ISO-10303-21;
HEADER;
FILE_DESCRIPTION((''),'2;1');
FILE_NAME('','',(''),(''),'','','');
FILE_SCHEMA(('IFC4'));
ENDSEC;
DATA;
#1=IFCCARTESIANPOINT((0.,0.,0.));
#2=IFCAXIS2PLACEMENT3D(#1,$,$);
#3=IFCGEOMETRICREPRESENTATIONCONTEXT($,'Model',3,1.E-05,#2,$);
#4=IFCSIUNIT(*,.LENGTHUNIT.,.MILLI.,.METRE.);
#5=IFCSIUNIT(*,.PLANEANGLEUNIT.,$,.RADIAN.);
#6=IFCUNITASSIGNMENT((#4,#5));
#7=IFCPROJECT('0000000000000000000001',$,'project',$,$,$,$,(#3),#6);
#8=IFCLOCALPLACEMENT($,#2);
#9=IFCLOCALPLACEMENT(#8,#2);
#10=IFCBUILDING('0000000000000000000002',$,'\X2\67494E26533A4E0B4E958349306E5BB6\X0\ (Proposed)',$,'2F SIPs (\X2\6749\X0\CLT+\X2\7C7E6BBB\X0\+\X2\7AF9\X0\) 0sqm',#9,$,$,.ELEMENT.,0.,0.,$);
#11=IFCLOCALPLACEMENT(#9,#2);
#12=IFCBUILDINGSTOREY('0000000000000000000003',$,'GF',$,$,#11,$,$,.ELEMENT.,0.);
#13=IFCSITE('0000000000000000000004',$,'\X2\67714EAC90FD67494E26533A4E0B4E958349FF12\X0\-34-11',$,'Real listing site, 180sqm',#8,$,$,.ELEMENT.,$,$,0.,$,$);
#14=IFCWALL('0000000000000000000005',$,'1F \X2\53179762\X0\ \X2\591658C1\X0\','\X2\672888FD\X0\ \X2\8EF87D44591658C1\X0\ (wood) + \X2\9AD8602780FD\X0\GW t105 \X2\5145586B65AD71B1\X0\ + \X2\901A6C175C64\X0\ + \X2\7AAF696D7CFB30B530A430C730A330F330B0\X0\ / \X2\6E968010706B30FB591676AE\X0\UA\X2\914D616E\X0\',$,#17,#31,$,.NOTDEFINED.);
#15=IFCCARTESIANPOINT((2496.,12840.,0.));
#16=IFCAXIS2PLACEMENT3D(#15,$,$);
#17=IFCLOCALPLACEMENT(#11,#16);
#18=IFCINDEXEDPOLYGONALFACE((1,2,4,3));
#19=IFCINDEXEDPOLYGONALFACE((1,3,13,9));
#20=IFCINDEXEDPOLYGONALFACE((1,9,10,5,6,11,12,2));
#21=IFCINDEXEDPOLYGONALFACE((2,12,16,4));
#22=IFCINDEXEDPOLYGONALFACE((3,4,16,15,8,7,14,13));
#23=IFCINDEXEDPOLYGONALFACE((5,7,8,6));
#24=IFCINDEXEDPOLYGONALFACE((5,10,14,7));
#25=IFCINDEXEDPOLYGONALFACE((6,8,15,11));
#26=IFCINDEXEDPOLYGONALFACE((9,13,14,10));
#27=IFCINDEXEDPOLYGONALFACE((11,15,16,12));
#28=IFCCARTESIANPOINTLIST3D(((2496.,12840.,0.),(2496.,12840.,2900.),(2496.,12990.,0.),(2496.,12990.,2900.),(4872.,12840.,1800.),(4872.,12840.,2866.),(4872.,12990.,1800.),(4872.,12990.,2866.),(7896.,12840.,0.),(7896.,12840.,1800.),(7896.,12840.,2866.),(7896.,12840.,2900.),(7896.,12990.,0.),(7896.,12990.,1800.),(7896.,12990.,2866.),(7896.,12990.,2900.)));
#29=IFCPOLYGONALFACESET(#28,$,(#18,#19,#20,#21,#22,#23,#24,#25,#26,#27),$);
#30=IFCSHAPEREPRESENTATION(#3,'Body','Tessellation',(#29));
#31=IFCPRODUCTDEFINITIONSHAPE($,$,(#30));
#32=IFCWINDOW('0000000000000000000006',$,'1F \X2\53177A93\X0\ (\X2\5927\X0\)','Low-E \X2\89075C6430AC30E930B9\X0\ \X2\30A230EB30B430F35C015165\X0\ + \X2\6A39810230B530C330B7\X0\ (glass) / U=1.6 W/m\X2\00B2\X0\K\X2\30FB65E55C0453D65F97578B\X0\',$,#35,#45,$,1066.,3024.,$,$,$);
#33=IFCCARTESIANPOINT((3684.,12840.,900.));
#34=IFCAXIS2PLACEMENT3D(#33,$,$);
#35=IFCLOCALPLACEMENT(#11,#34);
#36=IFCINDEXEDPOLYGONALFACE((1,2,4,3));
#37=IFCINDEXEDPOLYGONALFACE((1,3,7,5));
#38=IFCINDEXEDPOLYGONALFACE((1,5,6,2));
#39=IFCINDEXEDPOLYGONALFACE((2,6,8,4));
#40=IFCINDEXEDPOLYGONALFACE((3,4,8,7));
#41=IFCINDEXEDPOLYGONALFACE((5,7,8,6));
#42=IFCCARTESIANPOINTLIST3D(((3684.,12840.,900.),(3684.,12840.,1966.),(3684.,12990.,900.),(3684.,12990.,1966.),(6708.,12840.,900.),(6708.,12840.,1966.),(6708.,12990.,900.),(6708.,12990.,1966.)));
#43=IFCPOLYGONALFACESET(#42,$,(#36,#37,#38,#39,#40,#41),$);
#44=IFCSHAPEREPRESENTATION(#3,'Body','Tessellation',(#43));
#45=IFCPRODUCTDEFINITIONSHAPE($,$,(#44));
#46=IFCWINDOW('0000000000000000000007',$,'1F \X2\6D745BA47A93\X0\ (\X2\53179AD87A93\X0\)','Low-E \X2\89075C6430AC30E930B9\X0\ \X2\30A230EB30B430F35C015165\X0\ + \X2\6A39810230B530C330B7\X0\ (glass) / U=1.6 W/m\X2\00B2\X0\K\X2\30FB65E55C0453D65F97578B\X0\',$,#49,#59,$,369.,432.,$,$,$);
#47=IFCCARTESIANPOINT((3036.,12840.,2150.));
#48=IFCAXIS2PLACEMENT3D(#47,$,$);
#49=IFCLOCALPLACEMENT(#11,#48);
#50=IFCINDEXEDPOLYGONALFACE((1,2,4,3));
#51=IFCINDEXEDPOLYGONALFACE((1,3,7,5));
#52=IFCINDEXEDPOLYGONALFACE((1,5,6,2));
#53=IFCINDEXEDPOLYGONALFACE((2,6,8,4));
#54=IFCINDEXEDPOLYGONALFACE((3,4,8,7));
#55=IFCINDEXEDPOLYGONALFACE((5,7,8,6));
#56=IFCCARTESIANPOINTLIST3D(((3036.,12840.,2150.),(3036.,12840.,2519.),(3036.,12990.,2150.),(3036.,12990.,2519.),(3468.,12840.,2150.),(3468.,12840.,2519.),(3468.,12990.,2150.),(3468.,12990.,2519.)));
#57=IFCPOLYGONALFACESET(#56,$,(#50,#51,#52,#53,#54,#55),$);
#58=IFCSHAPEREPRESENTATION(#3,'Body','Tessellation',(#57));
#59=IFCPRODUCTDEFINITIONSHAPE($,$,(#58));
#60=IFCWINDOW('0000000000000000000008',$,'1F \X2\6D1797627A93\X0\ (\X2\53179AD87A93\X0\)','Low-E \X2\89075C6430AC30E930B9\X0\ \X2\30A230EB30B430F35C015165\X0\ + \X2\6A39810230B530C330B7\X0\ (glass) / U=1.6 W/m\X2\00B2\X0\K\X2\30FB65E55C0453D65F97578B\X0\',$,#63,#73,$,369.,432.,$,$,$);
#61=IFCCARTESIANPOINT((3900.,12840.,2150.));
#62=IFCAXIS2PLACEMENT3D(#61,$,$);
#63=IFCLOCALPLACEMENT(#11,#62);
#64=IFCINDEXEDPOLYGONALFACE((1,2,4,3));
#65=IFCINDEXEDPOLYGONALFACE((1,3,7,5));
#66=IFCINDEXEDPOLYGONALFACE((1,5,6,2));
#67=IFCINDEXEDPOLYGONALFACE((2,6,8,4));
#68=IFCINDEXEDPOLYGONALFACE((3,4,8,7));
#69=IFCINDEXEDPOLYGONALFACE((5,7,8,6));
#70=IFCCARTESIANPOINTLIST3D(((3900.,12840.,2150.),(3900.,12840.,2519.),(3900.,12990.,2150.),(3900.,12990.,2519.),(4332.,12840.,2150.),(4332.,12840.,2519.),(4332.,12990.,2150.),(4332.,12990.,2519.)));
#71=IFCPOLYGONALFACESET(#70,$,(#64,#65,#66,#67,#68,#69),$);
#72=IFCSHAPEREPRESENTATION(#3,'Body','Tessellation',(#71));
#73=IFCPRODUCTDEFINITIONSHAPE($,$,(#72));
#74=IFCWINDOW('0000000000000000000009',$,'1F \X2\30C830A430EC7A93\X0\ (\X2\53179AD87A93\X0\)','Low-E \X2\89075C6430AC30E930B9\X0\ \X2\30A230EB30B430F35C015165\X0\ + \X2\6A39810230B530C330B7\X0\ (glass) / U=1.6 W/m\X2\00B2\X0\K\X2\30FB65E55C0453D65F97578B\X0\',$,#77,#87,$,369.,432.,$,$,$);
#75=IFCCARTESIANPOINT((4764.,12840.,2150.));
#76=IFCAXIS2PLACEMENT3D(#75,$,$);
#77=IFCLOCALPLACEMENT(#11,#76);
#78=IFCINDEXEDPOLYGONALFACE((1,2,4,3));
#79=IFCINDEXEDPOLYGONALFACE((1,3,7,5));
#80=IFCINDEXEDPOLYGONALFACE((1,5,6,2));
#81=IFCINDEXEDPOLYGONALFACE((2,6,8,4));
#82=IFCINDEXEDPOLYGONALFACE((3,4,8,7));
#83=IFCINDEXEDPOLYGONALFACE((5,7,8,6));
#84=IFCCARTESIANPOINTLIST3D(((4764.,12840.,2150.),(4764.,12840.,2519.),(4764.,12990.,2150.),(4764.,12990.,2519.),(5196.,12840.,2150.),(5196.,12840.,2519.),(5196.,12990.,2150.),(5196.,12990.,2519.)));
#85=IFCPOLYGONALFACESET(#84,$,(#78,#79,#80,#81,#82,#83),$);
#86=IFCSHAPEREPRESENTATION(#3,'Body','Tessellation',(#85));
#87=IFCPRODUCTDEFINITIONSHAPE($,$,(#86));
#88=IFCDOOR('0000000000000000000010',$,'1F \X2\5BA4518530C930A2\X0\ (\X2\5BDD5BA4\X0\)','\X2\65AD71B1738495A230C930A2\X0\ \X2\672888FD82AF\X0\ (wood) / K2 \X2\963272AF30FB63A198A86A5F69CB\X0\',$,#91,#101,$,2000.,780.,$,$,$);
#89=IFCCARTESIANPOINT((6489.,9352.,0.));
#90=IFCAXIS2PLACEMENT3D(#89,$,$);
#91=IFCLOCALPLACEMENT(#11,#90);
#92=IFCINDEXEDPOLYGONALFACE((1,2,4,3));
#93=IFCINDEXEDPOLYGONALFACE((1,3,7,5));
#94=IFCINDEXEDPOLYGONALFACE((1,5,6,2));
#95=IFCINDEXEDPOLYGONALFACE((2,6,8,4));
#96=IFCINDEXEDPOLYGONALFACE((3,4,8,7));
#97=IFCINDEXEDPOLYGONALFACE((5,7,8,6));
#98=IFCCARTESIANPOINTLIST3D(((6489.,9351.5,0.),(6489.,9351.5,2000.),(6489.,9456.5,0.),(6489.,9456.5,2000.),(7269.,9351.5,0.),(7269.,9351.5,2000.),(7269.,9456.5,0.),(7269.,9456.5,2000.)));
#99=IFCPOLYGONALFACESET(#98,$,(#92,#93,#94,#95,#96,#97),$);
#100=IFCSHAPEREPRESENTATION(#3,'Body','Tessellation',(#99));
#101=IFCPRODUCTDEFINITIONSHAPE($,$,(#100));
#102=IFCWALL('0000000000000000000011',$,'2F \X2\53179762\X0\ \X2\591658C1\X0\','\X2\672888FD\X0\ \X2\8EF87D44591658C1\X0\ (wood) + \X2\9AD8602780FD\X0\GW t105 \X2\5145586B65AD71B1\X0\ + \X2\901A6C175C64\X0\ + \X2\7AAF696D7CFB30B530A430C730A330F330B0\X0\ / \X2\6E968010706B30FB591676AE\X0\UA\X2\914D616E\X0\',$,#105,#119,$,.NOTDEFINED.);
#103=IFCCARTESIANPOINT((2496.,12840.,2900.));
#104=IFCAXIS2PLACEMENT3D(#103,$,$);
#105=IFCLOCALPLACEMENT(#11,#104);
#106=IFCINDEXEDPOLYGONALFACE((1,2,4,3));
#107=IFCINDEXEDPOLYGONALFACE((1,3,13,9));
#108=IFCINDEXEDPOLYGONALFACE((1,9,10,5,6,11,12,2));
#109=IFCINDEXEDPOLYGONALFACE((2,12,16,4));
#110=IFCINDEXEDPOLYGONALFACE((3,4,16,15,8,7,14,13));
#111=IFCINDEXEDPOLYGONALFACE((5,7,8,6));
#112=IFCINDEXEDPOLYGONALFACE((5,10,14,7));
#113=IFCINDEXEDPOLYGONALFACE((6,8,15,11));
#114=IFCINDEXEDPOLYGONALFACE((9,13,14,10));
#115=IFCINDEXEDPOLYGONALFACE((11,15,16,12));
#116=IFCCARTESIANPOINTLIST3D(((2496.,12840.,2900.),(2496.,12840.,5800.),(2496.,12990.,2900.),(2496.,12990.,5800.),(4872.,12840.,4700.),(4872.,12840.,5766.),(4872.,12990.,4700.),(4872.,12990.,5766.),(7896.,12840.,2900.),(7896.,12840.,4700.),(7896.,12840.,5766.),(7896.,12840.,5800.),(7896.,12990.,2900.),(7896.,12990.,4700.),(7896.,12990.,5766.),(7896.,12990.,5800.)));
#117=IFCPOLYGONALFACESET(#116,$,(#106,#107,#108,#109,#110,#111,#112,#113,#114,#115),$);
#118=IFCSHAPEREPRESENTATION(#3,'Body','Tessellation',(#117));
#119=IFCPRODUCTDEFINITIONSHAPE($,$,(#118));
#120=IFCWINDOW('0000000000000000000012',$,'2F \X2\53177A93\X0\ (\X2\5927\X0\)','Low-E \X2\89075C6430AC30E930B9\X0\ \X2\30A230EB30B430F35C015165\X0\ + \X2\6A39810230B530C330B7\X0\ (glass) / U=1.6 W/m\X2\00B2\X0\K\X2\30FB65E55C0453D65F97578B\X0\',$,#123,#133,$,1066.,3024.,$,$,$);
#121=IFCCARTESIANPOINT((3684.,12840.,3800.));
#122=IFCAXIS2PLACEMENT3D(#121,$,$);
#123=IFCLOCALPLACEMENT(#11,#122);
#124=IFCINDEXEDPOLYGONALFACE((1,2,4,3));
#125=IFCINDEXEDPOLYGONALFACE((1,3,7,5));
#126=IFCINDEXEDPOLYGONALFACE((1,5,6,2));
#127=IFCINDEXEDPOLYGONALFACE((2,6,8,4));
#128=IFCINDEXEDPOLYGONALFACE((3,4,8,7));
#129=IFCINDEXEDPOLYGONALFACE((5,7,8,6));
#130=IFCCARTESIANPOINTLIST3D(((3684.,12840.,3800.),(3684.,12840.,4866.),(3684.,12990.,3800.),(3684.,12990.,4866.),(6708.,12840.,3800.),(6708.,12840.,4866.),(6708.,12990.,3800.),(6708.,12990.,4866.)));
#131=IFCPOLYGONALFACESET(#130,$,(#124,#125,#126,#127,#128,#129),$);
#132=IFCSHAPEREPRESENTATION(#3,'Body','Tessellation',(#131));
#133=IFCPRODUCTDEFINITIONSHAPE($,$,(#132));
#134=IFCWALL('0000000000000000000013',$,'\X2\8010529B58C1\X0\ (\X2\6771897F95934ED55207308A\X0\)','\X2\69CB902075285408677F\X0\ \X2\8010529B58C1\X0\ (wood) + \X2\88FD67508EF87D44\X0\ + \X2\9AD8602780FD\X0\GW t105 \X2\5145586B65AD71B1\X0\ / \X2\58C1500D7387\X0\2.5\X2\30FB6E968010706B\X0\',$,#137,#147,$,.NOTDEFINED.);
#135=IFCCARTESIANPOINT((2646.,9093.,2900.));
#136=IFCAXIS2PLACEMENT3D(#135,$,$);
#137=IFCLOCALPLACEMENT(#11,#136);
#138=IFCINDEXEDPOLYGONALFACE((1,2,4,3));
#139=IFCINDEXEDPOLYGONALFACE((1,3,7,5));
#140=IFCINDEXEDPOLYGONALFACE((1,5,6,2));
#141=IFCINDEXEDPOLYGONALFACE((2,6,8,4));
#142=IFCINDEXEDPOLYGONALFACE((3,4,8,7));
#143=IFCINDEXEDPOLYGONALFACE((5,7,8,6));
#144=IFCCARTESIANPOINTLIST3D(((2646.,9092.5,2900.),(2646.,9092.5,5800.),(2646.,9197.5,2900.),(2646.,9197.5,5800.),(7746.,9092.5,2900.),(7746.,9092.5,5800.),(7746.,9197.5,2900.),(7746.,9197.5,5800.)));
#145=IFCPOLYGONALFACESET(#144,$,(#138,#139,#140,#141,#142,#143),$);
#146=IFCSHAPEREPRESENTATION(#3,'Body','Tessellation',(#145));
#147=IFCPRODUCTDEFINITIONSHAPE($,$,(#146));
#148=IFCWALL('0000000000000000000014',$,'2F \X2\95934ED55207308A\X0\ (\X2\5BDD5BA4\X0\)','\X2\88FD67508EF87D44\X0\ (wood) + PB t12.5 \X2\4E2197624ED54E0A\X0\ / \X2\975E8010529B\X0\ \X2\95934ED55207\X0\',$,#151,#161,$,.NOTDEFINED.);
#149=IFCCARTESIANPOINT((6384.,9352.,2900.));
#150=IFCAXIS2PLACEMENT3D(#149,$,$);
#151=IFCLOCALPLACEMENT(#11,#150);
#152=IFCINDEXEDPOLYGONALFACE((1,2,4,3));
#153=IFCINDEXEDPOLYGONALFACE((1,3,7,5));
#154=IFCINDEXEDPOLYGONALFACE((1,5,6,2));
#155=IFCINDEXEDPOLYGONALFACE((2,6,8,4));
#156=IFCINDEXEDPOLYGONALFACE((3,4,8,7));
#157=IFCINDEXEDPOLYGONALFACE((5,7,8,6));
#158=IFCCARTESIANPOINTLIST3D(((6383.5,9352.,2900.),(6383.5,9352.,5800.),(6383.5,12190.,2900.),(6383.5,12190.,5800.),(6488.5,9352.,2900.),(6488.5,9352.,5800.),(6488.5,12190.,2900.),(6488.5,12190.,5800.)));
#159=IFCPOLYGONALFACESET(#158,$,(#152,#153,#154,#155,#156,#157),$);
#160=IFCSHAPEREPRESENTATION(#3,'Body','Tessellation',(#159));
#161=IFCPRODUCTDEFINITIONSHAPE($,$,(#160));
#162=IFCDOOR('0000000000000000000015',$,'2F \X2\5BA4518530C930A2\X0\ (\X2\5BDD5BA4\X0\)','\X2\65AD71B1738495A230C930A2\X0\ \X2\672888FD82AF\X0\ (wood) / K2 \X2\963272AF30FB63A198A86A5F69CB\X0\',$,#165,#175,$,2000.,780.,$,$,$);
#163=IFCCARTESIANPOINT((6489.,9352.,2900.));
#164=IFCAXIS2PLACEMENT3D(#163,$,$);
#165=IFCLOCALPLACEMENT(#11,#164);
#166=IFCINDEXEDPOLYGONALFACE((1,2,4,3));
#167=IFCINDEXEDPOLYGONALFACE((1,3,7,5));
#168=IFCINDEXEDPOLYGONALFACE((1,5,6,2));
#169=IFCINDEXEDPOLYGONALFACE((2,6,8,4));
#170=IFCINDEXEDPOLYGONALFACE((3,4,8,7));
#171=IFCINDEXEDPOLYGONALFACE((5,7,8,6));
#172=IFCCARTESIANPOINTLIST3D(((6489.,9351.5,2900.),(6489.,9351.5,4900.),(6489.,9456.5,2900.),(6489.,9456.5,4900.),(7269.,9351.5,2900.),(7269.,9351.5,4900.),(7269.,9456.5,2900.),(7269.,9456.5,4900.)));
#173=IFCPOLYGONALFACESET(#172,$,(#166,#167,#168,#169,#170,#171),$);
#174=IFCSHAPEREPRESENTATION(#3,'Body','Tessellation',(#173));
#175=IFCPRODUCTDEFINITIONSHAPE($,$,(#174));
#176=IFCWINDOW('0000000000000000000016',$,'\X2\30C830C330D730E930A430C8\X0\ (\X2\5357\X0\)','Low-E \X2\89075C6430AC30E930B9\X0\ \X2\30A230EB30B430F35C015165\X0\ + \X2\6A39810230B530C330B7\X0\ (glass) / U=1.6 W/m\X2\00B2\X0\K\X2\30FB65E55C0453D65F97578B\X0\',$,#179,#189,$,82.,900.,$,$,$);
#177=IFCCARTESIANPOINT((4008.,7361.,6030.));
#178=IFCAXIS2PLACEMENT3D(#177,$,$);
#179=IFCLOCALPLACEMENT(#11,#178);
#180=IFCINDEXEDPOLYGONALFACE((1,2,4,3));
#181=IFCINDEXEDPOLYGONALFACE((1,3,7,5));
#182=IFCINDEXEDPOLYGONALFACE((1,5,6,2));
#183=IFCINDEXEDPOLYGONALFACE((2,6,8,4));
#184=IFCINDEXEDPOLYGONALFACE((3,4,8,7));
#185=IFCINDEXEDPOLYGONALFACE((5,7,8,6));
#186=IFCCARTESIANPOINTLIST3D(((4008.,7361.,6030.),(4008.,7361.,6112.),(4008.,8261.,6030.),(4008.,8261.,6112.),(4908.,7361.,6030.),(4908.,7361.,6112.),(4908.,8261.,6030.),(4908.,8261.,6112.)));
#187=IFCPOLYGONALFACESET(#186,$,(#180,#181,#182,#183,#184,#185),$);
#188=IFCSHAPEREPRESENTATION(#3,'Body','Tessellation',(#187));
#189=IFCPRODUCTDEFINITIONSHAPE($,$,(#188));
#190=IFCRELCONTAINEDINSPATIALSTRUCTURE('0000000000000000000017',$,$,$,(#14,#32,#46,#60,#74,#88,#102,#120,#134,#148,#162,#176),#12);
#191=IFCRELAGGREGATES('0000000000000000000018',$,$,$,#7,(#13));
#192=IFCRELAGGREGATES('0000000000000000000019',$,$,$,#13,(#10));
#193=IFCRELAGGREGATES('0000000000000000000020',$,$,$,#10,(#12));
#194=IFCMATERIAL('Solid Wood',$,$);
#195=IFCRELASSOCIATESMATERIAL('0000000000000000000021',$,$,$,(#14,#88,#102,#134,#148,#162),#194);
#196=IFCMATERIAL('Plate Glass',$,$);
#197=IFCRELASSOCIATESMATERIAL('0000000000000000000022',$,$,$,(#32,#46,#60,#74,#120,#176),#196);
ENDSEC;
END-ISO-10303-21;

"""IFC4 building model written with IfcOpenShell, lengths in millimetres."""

from ifc_helpers import new_model, si_unit, frame, frame_2d, origin, place, context, project, spatial, rectangle, extrude, material, element, fill, save


model = new_model("IFC4")

# Units and contexts
model_context = context("Model", 3, precision=1e-05, world=origin())
ifc_project = project(units=[si_unit("LENGTHUNIT", "METRE", prefix="MILLI"), si_unit("PLANEANGLEUNIT", "RADIAN")], contexts=[model_context])

# Site, building, storey
site_placement = place(None, origin())
site = spatial("IfcSite", under=ifc_project, at=site_placement, Name="東京都杉並区下井草２-34-11", ObjectType="Real listing site, 180sqm", CompositionType="ELEMENT", RefElevation=0.0)
building_placement = place(site_placement, origin())
building = spatial("IfcBuilding", under=site, at=building_placement, Name="杉並区下井草の家 (Proposed)", ObjectType="2F SIPs (杉CLT+籾殻+竹) 0sqm", CompositionType="ELEMENT", ElevationOfRefHeight=0.0, ElevationOfTerrain=0.0)
storey_placement = place(building_placement, origin())
storey = spatial("IfcBuildingStorey", under=building, at=storey_placement, Name="GF", CompositionType="ELEMENT", Elevation=0.0)

# Wall, openings, windows
ifc_material_1 = material(Name="Solid Wood")
wall_1_placement = place(storey_placement, frame((2496.0, 12840.0, 0.0)))
wall_1 = element("IfcWall", 1, at=wall_1_placement, inside=storey, material=ifc_material_1, Name="1F 北面 外壁", Description="木製 軸組外壁 (wood) + 高性能GW t105 充填断熱 + 通気層 + 窯業系サイディング / 準耐火・外皮UA配慮", PredefinedType="NOTDEFINED", context=model_context, shape_type="SweptSolid", body=[
    extrude(rectangle(XDim=5400.0, YDim=150.0, at=frame_2d((2700.0, 75.0))), frame((2496.0, 12840.0, 0.0)), (0.0, 0.0, 1.0), 2900.0),
])
opening_1_placement = place(storey_placement, frame((3684.0, 12840.0, 900.0)))
opening_1 = element("IfcOpeningElement", 2, at=opening_1_placement, cuts=wall_1, PredefinedType="NOTDEFINED", context=model_context, shape_type="SweptSolid", body=[
    extrude(rectangle(XDim=3024.0, YDim=150.0, at=frame_2d((1512.0, 75.0))), frame((3684.0, 12840.0, 900.0)), (0.0, 0.0, 1.0), 1066.0),
])
opening_2_placement = place(storey_placement, frame((3036.0, 12840.0, 2150.0)))
opening_2 = element("IfcOpeningElement", 3, at=opening_2_placement, cuts=wall_1, PredefinedType="NOTDEFINED", context=model_context, shape_type="SweptSolid", body=[
    extrude(rectangle(XDim=432.0, YDim=150.0, at=frame_2d((216.0, 75.0))), frame((3036.0, 12840.0, 2150.0)), (0.0, 0.0, 1.0), 369.0),
])
opening_3_placement = place(storey_placement, frame((3900.0, 12840.0, 2150.0)))
opening_3 = element("IfcOpeningElement", 4, at=opening_3_placement, cuts=wall_1, PredefinedType="NOTDEFINED", context=model_context, shape_type="SweptSolid", body=[
    extrude(rectangle(XDim=432.0, YDim=150.0, at=frame_2d((216.0, 75.0))), frame((3900.0, 12840.0, 2150.0)), (0.0, 0.0, 1.0), 369.0),
])
opening_4_placement = place(storey_placement, frame((4764.0, 12840.0, 2150.0)))
opening_4 = element("IfcOpeningElement", 5, at=opening_4_placement, cuts=wall_1, PredefinedType="NOTDEFINED", context=model_context, shape_type="SweptSolid", body=[
    extrude(rectangle(XDim=432.0, YDim=150.0, at=frame_2d((216.0, 75.0))), frame((4764.0, 12840.0, 2150.0)), (0.0, 0.0, 1.0), 369.0),
])
ifc_material_2 = material(Name="Plate Glass")
window_1_placement = place(storey_placement, frame((3684.0, 12840.0, 900.0)))
window_1 = element("IfcWindow", 6, at=window_1_placement, inside=storey, material=ifc_material_2, Name="1F 北窓 (大)", Description="Low-E 複層ガラス アルゴン封入 + 樹脂サッシ (glass) / U=1.6 W/m²K・日射取得型", OverallHeight=1066.0, OverallWidth=3024.0, context=model_context, shape_type="SweptSolid", body=[
    extrude(rectangle(XDim=3024.0, YDim=150.0, at=frame_2d((1512.0, 75.0))), frame((3684.0, 12840.0, 900.0)), (0.0, 0.0, 1.0), 1066.0),
])
fill(opening_1, window_1)
window_2_placement = place(storey_placement, frame((3036.0, 12840.0, 2150.0)))
window_2 = element("IfcWindow", 7, at=window_2_placement, inside=storey, material=ifc_material_2, Name="1F 浴室窓 (北高窓)", Description="Low-E 複層ガラス アルゴン封入 + 樹脂サッシ (glass) / U=1.6 W/m²K・日射取得型", OverallHeight=369.0, OverallWidth=432.0, context=model_context, shape_type="SweptSolid", body=[
    extrude(rectangle(XDim=432.0, YDim=150.0, at=frame_2d((216.0, 75.0))), frame((3036.0, 12840.0, 2150.0)), (0.0, 0.0, 1.0), 369.0),
])
fill(opening_2, window_2)
window_3_placement = place(storey_placement, frame((3900.0, 12840.0, 2150.0)))
window_3 = element("IfcWindow", 8, at=window_3_placement, inside=storey, material=ifc_material_2, Name="1F 洗面窓 (北高窓)", Description="Low-E 複層ガラス アルゴン封入 + 樹脂サッシ (glass) / U=1.6 W/m²K・日射取得型", OverallHeight=369.0, OverallWidth=432.0, context=model_context, shape_type="SweptSolid", body=[
    extrude(rectangle(XDim=432.0, YDim=150.0, at=frame_2d((216.0, 75.0))), frame((3900.0, 12840.0, 2150.0)), (0.0, 0.0, 1.0), 369.0),
])
fill(opening_3, window_3)
window_4_placement = place(storey_placement, frame((4764.0, 12840.0, 2150.0)))
window_4 = element("IfcWindow", 9, at=window_4_placement, inside=storey, material=ifc_material_2, Name="1F トイレ窓 (北高窓)", Description="Low-E 複層ガラス アルゴン封入 + 樹脂サッシ (glass) / U=1.6 W/m²K・日射取得型", OverallHeight=369.0, OverallWidth=432.0, context=model_context, shape_type="SweptSolid", body=[
    extrude(rectangle(XDim=432.0, YDim=150.0, at=frame_2d((216.0, 75.0))), frame((4764.0, 12840.0, 2150.0)), (0.0, 0.0, 1.0), 369.0),
])
fill(opening_4, window_4)

# Door
door_1_placement = place(storey_placement, frame((6489.0, 9352.0, 0.0)))
element("IfcDoor", 10, at=door_1_placement, inside=storey, material=ifc_material_1, Name="1F 室内ドア (寝室)", Description="断熱玄関ドア 木製芯 (wood) / K2 防犯・採風機構", OverallHeight=2000.0, OverallWidth=780.0, context=model_context, shape_type="SweptSolid", body=[
    extrude(rectangle(XDim=780.0, YDim=105.0, at=frame_2d((390.0, 52.0))), frame((6489.0, 9352.0, 0.0)), (0.0, 0.0, 1.0), 2000.0),
])

# Wall, opening, window
wall_2_placement = place(storey_placement, frame((2496.0, 12840.0, 2900.0)))
wall_2 = element("IfcWall", 11, at=wall_2_placement, inside=storey, material=ifc_material_1, Name="2F 北面 外壁", Description="木製 軸組外壁 (wood) + 高性能GW t105 充填断熱 + 通気層 + 窯業系サイディング / 準耐火・外皮UA配慮", PredefinedType="NOTDEFINED", context=model_context, shape_type="SweptSolid", body=[
    extrude(rectangle(XDim=5400.0, YDim=150.0, at=frame_2d((2700.0, 75.0))), frame((2496.0, 12840.0, 2900.0)), (0.0, 0.0, 1.0), 2900.0),
])
opening_5_placement = place(storey_placement, frame((3684.0, 12840.0, 3800.0)))
opening_5 = element("IfcOpeningElement", 12, at=opening_5_placement, cuts=wall_2, PredefinedType="NOTDEFINED", context=model_context, shape_type="SweptSolid", body=[
    extrude(rectangle(XDim=3024.0, YDim=150.0, at=frame_2d((1512.0, 75.0))), frame((3684.0, 12840.0, 3800.0)), (0.0, 0.0, 1.0), 1066.0),
])
window_5_placement = place(storey_placement, frame((3684.0, 12840.0, 3800.0)))
window_5 = element("IfcWindow", 13, at=window_5_placement, inside=storey, material=ifc_material_2, Name="2F 北窓 (大)", Description="Low-E 複層ガラス アルゴン封入 + 樹脂サッシ (glass) / U=1.6 W/m²K・日射取得型", OverallHeight=1066.0, OverallWidth=3024.0, context=model_context, shape_type="SweptSolid", body=[
    extrude(rectangle(XDim=3024.0, YDim=150.0, at=frame_2d((1512.0, 75.0))), frame((3684.0, 12840.0, 3800.0)), (0.0, 0.0, 1.0), 1066.0),
])
fill(opening_5, window_5)

# Walls
wall_3_placement = place(storey_placement, frame((2646.0, 9093.0, 2900.0)))
element("IfcWall", 14, at=wall_3_placement, inside=storey, material=ifc_material_1, Name="耐力壁 (東西間仕切り)", Description="構造用合板 耐力壁 (wood) + 製材軸組 + 高性能GW t105 充填断熱 / 壁倍率2.5・準耐火", PredefinedType="NOTDEFINED", context=model_context, shape_type="SweptSolid", body=[
    extrude(rectangle(XDim=5100.0, YDim=105.0, at=frame_2d((2550.0, 52.0))), frame((2646.0, 9093.0, 2900.0)), (0.0, 0.0, 1.0), 2900.0),
])
wall_4_placement = place(storey_placement, frame((6384.0, 9352.0, 2900.0)))
element("IfcWall", 15, at=wall_4_placement, inside=storey, material=ifc_material_1, Name="2F 間仕切り (寝室)", Description="製材軸組 (wood) + PB t12.5 両面仕上 / 非耐力 間仕切", PredefinedType="NOTDEFINED", context=model_context, shape_type="SweptSolid", body=[
    extrude(rectangle(XDim=105.0, YDim=2838.0, at=frame_2d((52.0, 1419.0))), frame((6384.0, 9352.0, 2900.0)), (0.0, 0.0, 1.0), 2900.0),
])

# Door
door_2_placement = place(storey_placement, frame((6489.0, 9352.0, 2900.0)))
element("IfcDoor", 16, at=door_2_placement, inside=storey, material=ifc_material_1, Name="2F 室内ドア (寝室)", Description="断熱玄関ドア 木製芯 (wood) / K2 防犯・採風機構", OverallHeight=2000.0, OverallWidth=780.0, context=model_context, shape_type="SweptSolid", body=[
    extrude(rectangle(XDim=780.0, YDim=105.0, at=frame_2d((390.0, 52.0))), frame((6489.0, 9352.0, 2900.0)), (0.0, 0.0, 1.0), 2000.0),
])

# Window
window_6_placement = place(storey_placement, frame((4008.0, 7361.0, 6030.0)))
element("IfcWindow", 17, at=window_6_placement, inside=storey, material=ifc_material_2, Name="トップライト (南)", Description="Low-E 複層ガラス アルゴン封入 + 樹脂サッシ (glass) / U=1.6 W/m²K・日射取得型", OverallHeight=82.0, OverallWidth=900.0, context=model_context, shape_type="SweptSolid", body=[
    extrude(rectangle(XDim=900.0, YDim=900.0, at=frame_2d((450.0, 450.0))), frame((4008.0, 7361.0, 6030.0)), (0.0, 0.0, 1.0), 82.0),
])

save(model, "model.ifc")
